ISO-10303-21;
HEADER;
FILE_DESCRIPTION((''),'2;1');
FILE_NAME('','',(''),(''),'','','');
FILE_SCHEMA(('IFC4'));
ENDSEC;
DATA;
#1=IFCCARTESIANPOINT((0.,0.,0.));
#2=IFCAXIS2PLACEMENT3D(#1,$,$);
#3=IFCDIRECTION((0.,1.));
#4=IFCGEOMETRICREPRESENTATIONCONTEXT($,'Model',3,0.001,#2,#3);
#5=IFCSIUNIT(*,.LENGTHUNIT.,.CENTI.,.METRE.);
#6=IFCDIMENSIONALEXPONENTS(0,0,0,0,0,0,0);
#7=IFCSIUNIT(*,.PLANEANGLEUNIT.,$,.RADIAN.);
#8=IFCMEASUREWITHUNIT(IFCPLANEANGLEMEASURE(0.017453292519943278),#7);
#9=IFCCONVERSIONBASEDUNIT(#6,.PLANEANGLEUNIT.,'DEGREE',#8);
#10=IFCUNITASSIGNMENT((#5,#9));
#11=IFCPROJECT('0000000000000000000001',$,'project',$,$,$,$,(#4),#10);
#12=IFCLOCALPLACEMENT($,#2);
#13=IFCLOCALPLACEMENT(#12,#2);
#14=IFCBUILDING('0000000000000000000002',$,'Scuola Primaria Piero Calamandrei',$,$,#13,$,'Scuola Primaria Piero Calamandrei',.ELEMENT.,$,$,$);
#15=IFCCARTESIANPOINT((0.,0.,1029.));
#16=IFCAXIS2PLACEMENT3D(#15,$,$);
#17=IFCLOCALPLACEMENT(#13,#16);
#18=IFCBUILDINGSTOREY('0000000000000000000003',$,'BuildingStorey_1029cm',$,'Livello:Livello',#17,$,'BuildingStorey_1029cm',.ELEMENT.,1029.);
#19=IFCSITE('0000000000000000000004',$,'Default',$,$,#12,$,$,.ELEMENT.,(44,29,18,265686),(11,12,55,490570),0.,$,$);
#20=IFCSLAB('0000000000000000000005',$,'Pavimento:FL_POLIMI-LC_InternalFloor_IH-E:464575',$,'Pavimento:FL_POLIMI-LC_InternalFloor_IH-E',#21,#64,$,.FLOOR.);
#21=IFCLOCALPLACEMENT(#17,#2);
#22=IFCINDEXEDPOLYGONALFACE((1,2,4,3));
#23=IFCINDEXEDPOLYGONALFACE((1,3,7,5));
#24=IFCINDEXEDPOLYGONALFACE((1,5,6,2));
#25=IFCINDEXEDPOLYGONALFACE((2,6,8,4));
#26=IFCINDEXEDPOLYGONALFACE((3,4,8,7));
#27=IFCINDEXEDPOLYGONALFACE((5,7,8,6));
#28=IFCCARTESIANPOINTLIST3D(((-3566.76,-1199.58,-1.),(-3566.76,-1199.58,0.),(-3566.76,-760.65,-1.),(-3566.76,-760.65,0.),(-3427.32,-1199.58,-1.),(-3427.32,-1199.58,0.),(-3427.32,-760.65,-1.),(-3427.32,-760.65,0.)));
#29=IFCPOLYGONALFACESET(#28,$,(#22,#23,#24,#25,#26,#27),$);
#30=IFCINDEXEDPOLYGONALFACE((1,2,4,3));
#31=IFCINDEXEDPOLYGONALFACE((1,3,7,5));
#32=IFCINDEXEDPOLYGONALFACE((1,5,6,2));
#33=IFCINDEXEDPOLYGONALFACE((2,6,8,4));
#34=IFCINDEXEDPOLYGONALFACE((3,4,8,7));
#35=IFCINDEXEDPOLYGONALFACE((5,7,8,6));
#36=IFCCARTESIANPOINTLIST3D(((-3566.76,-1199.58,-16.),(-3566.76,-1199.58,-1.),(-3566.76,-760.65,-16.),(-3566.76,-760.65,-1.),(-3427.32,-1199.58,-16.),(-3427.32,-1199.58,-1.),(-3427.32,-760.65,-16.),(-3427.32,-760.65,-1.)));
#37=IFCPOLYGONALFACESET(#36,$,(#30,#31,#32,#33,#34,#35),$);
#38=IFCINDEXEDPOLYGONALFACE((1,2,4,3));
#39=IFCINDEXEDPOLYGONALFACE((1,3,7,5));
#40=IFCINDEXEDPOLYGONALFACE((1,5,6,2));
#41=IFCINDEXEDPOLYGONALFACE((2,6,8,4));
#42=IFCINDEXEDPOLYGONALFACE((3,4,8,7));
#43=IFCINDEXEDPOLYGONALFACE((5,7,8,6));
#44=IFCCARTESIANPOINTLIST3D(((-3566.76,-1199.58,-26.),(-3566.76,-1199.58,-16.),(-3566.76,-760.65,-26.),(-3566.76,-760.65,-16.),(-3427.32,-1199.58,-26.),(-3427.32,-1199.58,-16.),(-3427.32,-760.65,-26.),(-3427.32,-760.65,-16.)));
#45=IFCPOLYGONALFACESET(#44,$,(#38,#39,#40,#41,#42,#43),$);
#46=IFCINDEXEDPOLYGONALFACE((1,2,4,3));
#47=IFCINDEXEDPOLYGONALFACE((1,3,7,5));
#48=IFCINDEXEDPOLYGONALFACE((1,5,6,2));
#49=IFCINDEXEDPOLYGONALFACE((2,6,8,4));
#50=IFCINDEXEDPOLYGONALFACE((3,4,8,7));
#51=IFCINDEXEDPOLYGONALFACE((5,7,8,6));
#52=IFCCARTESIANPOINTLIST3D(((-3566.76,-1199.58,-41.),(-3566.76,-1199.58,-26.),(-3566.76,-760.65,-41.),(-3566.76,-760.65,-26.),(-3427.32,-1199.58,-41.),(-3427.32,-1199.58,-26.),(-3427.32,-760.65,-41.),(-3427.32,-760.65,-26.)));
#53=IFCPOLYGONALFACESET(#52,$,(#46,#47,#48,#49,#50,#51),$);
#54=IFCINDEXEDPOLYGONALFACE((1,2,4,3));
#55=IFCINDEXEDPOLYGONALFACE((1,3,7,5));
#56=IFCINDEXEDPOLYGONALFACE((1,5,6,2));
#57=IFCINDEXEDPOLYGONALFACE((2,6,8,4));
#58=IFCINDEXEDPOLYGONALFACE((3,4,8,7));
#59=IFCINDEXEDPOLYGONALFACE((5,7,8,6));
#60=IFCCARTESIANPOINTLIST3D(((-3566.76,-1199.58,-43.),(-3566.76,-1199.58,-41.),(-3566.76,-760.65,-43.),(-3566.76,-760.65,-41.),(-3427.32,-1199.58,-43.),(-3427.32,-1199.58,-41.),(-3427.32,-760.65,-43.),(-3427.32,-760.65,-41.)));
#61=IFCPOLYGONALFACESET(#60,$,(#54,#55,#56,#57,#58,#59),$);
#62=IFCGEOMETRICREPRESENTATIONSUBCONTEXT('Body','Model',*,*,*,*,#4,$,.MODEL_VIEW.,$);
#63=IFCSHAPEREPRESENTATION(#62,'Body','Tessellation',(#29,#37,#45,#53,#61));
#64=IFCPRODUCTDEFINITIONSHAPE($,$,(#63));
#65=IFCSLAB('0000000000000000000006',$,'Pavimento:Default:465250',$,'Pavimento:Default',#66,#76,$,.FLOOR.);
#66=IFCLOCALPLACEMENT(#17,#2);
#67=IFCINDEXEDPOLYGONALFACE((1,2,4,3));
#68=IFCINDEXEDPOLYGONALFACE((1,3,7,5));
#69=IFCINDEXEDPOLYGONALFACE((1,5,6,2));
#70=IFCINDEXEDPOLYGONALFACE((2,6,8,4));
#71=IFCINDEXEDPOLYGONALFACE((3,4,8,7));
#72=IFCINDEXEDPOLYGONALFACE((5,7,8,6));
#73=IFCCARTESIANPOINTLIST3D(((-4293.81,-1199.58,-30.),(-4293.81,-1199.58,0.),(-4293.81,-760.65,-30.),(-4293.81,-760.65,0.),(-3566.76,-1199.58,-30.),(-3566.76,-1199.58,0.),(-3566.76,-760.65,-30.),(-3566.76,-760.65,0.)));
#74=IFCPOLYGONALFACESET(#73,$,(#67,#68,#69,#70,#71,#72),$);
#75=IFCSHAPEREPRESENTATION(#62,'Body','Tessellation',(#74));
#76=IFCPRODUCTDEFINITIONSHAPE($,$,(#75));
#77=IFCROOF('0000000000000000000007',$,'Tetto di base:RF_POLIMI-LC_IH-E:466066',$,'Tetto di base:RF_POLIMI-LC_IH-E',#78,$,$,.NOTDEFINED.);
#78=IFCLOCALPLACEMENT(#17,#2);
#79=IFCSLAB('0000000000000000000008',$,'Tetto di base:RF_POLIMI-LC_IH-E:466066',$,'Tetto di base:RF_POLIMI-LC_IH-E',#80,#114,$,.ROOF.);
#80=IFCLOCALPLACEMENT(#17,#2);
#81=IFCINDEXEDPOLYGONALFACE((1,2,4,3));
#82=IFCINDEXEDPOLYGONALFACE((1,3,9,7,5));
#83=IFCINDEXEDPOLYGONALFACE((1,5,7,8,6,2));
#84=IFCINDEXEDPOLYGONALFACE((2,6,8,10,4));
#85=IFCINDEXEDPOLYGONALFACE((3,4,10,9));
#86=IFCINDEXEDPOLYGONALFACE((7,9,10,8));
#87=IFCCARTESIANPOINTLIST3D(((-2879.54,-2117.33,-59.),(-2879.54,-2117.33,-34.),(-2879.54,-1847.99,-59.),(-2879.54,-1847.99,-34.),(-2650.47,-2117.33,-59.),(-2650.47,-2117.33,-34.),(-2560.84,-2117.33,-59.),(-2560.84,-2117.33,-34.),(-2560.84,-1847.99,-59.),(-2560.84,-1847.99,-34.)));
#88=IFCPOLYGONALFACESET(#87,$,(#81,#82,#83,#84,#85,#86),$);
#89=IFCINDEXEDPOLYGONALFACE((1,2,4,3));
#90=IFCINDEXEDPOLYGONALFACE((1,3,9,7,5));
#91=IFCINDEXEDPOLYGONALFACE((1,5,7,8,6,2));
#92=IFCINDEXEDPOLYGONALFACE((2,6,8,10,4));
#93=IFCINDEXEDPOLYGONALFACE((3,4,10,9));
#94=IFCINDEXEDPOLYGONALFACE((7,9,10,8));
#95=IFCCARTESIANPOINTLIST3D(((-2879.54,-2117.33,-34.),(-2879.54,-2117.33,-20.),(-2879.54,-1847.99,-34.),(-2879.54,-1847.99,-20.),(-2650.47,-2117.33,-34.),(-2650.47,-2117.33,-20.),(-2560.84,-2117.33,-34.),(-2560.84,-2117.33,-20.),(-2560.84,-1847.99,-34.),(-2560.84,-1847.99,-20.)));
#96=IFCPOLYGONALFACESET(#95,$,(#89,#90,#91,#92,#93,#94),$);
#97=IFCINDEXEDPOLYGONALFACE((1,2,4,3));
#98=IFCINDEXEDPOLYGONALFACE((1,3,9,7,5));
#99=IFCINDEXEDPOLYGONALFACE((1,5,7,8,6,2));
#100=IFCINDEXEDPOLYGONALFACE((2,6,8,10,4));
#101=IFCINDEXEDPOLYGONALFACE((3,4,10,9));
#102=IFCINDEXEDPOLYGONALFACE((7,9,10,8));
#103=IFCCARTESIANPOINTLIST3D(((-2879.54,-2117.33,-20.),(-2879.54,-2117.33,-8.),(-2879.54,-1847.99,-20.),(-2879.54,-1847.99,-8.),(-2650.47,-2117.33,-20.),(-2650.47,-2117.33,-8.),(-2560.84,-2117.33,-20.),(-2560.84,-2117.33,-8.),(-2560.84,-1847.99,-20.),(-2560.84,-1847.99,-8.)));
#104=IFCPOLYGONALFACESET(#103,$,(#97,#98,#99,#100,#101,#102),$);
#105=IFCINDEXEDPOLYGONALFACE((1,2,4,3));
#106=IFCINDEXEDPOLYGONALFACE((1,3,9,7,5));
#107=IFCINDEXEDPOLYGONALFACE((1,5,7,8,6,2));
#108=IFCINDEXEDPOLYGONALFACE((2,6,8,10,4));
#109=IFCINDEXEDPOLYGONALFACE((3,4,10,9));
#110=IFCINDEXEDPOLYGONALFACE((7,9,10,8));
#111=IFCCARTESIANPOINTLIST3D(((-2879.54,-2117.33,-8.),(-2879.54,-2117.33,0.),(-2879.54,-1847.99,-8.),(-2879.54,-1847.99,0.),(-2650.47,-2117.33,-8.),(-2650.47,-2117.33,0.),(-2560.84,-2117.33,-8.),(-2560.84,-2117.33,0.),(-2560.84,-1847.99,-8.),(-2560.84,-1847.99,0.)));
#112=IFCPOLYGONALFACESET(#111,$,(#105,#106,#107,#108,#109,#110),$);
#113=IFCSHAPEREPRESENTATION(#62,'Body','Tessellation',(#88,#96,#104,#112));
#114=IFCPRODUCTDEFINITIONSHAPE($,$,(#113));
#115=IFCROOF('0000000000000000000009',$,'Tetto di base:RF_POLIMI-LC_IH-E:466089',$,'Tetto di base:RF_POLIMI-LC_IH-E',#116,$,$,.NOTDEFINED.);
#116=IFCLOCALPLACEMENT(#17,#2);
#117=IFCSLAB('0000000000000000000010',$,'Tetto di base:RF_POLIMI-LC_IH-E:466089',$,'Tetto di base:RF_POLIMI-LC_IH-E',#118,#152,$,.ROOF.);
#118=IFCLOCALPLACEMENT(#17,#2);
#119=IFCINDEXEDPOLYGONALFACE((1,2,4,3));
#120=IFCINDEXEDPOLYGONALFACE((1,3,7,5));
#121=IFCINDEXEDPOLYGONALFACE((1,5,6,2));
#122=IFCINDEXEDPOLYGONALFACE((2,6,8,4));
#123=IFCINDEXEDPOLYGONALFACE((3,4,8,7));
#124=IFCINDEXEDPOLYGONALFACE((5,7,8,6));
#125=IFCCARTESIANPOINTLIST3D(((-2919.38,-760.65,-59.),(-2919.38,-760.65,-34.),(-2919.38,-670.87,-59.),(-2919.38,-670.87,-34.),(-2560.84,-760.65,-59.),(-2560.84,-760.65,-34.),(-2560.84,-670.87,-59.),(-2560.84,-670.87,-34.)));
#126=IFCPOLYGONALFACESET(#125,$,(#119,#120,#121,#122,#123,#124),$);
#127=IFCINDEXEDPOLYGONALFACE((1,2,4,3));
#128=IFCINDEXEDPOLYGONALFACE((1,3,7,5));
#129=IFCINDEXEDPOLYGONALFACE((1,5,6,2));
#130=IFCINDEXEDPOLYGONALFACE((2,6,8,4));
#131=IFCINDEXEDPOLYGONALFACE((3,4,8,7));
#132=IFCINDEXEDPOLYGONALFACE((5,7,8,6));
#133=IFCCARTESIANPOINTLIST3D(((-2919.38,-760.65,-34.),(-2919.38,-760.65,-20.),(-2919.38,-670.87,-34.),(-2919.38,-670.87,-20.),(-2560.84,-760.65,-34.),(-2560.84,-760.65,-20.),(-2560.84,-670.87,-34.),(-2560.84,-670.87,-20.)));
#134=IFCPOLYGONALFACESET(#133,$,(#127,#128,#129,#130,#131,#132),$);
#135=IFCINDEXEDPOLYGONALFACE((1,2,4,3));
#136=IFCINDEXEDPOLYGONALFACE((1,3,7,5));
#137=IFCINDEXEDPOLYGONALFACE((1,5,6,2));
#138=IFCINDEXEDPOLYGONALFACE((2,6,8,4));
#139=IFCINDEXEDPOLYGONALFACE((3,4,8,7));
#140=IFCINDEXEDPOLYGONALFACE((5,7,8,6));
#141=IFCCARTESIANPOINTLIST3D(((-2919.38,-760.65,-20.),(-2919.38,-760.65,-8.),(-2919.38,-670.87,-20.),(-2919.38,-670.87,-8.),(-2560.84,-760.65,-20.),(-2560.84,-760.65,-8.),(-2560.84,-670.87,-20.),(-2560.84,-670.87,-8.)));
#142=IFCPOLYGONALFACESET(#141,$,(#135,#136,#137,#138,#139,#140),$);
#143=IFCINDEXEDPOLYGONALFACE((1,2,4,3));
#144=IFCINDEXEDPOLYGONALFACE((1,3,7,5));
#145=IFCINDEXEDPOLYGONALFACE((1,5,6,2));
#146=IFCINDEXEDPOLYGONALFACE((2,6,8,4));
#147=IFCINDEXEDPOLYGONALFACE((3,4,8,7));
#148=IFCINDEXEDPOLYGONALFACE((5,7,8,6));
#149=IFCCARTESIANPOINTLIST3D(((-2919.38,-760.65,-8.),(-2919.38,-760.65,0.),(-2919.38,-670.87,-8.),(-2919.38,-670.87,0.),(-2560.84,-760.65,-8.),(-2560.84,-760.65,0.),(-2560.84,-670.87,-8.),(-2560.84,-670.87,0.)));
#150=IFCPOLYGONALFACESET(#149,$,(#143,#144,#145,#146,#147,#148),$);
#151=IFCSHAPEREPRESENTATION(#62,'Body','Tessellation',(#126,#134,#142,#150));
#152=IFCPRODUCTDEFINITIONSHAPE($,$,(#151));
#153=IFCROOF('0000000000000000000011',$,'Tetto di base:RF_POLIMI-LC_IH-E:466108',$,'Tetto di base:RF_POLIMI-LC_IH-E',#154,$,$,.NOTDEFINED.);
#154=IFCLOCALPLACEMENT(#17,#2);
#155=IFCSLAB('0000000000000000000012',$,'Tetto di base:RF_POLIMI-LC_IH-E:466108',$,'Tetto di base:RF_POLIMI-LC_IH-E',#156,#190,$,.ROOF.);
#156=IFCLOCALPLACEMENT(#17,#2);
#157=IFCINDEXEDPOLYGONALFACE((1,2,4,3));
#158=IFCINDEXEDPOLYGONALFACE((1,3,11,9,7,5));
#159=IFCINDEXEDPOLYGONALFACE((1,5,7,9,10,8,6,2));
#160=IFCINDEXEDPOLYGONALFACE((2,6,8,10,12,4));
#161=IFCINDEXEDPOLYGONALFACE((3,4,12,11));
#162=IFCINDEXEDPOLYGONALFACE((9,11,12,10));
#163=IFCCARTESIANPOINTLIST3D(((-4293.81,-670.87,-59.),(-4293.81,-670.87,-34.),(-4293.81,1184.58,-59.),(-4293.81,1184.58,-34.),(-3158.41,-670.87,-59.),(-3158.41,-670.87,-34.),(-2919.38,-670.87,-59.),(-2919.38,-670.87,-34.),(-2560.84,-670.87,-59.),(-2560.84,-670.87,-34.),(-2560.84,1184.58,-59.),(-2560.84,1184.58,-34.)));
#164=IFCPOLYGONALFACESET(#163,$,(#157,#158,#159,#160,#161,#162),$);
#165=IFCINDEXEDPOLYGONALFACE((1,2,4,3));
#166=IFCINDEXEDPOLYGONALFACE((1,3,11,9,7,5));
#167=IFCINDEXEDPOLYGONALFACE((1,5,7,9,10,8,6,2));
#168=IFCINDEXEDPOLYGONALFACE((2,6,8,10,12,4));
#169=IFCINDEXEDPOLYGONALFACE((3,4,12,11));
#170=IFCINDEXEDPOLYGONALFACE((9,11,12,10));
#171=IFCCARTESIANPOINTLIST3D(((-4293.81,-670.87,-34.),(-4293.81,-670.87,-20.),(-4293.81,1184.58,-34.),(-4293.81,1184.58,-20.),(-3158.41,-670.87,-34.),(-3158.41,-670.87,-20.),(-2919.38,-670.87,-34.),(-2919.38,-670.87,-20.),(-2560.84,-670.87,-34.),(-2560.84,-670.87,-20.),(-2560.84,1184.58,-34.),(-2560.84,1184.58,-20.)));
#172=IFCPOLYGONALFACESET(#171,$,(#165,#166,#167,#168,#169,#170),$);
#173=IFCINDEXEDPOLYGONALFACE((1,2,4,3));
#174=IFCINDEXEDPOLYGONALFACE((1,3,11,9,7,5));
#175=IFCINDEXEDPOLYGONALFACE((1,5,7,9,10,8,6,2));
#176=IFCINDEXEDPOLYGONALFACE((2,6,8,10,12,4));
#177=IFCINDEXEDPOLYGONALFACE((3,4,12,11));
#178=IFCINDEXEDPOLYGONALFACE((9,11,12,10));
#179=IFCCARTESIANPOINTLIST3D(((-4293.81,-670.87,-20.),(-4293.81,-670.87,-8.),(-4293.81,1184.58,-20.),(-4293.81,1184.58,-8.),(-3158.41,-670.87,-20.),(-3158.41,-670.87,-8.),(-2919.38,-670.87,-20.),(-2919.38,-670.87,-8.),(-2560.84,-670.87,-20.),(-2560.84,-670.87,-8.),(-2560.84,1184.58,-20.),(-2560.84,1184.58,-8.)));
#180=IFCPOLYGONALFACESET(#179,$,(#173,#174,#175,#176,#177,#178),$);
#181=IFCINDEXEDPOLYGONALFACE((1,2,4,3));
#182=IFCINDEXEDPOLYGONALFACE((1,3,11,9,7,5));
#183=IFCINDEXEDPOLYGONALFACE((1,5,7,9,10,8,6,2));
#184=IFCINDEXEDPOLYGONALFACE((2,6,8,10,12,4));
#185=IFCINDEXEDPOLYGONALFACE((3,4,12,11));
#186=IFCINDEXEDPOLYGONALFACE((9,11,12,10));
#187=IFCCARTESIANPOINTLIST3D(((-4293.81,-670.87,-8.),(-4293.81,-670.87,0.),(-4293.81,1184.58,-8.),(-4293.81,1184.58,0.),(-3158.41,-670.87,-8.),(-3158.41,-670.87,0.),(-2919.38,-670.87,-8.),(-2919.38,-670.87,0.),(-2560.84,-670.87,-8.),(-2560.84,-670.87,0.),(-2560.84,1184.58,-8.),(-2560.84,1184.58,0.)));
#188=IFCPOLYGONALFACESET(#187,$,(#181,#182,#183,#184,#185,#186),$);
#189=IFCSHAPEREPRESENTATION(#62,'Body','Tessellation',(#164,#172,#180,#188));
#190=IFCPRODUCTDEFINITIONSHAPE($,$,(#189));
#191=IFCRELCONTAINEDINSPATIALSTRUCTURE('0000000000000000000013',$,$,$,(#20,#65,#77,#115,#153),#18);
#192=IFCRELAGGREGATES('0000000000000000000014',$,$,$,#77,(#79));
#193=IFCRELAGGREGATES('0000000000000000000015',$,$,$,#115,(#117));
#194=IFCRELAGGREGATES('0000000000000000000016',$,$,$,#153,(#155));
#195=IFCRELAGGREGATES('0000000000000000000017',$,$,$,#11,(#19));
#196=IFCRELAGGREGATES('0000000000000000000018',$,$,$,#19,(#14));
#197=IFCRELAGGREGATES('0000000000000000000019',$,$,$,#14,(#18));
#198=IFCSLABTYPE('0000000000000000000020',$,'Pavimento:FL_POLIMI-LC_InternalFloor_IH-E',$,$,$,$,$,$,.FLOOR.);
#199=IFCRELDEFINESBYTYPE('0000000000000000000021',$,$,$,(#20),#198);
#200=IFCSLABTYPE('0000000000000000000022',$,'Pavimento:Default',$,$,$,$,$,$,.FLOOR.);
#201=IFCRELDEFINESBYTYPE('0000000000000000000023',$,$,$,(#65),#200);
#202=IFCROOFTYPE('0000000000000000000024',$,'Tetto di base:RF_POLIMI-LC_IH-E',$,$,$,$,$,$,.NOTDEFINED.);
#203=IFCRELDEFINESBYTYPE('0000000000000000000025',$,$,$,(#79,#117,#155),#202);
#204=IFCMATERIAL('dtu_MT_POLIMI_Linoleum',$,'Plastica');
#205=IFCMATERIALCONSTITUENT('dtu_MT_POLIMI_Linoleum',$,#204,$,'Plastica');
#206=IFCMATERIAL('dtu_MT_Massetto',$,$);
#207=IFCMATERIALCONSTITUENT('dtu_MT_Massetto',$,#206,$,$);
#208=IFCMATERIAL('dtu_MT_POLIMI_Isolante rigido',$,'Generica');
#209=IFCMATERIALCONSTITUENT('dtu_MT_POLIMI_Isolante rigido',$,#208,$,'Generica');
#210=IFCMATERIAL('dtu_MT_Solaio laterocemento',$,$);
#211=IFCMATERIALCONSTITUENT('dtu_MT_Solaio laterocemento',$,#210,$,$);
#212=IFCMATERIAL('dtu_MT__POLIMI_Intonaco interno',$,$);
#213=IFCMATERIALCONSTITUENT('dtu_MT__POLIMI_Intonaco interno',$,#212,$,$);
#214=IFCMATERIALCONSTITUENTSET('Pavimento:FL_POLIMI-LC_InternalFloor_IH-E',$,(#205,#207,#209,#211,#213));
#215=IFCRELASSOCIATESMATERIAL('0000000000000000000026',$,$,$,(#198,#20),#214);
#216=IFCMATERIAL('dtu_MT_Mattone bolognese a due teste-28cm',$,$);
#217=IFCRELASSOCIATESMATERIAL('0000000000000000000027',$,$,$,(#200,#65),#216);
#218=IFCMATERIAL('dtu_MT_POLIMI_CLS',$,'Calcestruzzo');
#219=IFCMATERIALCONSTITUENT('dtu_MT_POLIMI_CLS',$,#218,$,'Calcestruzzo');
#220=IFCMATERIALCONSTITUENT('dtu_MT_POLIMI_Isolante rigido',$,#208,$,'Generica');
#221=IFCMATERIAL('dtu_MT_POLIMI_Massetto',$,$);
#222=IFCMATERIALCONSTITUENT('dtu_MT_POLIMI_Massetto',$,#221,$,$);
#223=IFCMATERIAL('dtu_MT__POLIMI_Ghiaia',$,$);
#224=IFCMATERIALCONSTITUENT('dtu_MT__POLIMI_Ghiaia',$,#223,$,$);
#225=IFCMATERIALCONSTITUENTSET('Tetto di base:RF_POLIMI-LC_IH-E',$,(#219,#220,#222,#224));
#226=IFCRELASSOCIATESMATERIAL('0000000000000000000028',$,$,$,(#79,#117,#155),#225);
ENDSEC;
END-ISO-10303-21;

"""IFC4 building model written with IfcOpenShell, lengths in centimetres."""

from ifc_helpers import new_model, entity, si_unit, converted_unit, direction, frame, origin, place, context, subcontext, project, spatial, indexed_curve, outline, extrude, material, constituent, constituent_set, type_object, element, aggregate, save


model = new_model("IFC4")

# Units and contexts
model_context = context("Model", 3, precision=0.001, world=origin(), true_north=direction((0.0, 1.0)))
body_context = subcontext(model_context, "Body", "Model", "MODEL_VIEW")
ifc_project = project(units=[si_unit("LENGTHUNIT", "METRE", prefix="CENTI"), converted_unit("PLANEANGLEUNIT", "DEGREE", entity("IfcPlaneAngleMeasure", 0.017453292519943278), si_unit("PLANEANGLEUNIT", "RADIAN"), dimensions=[0, 0, 0, 0, 0, 0, 0])], contexts=[model_context])

# Site, building, storey
site_placement = place(None, origin())
site = spatial("IfcSite", under=ifc_project, at=site_placement, Name="Default", CompositionType="ELEMENT", RefLatitude=(44, 29, 18, 265686), RefLongitude=(11, 12, 55, 490570), RefElevation=0.0)
building_placement = place(site_placement, origin())
building = spatial("IfcBuilding", under=site, at=building_placement, Name="Scuola Primaria Piero Calamandrei", LongName="Scuola Primaria Piero Calamandrei", CompositionType="ELEMENT")
storey_placement = place(building_placement, frame((0.0, 0.0, 1029.0)))
storey = spatial("IfcBuildingStorey", under=building, at=storey_placement, Name="BuildingStorey_1029cm", ObjectType="Livello:Livello", LongName="BuildingStorey_1029cm", CompositionType="ELEMENT", Elevation=1029.0)

# Slabs
ifc_material_1 = material(Name="dtu_MT_POLIMI_Linoleum", Category="Plastica")
ifc_constituent_1 = constituent(ifc_material_1, Name="dtu_MT_POLIMI_Linoleum", Category="Plastica")
ifc_material_2 = material(Name="dtu_MT_Massetto")
ifc_constituent_2 = constituent(ifc_material_2, Name="dtu_MT_Massetto")
ifc_material_3 = material(Name="dtu_MT_POLIMI_Isolante rigido", Category="Generica")
ifc_constituent_3 = constituent(ifc_material_3, Name="dtu_MT_POLIMI_Isolante rigido", Category="Generica")
ifc_material_4 = material(Name="dtu_MT_Solaio laterocemento")
ifc_constituent_4 = constituent(ifc_material_4, Name="dtu_MT_Solaio laterocemento")
ifc_material_5 = material(Name="dtu_MT__POLIMI_Intonaco interno")
ifc_constituent_5 = constituent(ifc_material_5, Name="dtu_MT__POLIMI_Intonaco interno")
ifc_constituent_set_1 = constituent_set(constituents=[ifc_constituent_1, ifc_constituent_2, ifc_constituent_3, ifc_constituent_4, ifc_constituent_5], Name="Pavimento:FL_POLIMI-LC_InternalFloor_IH-E")
slab_type_1 = type_object("IfcSlabType", Name="Pavimento:FL_POLIMI-LC_InternalFloor_IH-E", PredefinedType="FLOOR", material=ifc_constituent_set_1)
slab_1_placement = place(storey_placement, origin())
element("IfcSlab", 1, at=slab_1_placement, inside=storey, type_object=slab_type_1, material=ifc_constituent_set_1, Name="Pavimento:FL_POLIMI-LC_InternalFloor_IH-E:464575", ObjectType="Pavimento:FL_POLIMI-LC_InternalFloor_IH-E", PredefinedType="FLOOR", context=body_context, shape_type="SweptSolid", body=[
    extrude(outline(indexed_curve([(-69.72, -219.46), (69.72, -219.46), (69.72, 219.46), (-69.72, 219.46), (-69.72, -219.46)], self_intersect=False)), frame((-3497.04, -980.11, -1.0)), (0.0, 0.0, 1.0), 1.0),
    extrude(outline(indexed_curve([(-69.72, -219.46), (69.72, -219.46), (69.72, 219.46), (-69.72, 219.46), (-69.72, -219.46)], self_intersect=False)), frame((-3497.04, -980.11, -16.0)), (0.0, 0.0, 1.0), 15.0),
    extrude(outline(indexed_curve([(-69.72, -219.46), (69.72, -219.46), (69.72, 219.46), (-69.72, 219.46), (-69.72, -219.46)], self_intersect=False)), frame((-3497.04, -980.11, -26.0)), (0.0, 0.0, 1.0), 10.0),
    extrude(outline(indexed_curve([(-69.72, -219.46), (69.72, -219.46), (69.72, 219.46), (-69.72, 219.46), (-69.72, -219.46)], self_intersect=False)), frame((-3497.04, -980.11, -41.0)), (0.0, 0.0, 1.0), 15.0),
    extrude(outline(indexed_curve([(-69.72, -219.46), (69.72, -219.46), (69.72, 219.46), (-69.72, 219.46), (-69.72, -219.46)], self_intersect=False)), frame((-3497.04, -980.11, -43.0)), (0.0, 0.0, 1.0), 2.0),
])
ifc_material_6 = material(Name="dtu_MT_Mattone bolognese a due teste-28cm")
slab_type_2 = type_object("IfcSlabType", Name="Pavimento:Default", PredefinedType="FLOOR", material=ifc_material_6)
slab_2_placement = place(storey_placement, origin())
element("IfcSlab", 2, at=slab_2_placement, inside=storey, type_object=slab_type_2, material=ifc_material_6, Name="Pavimento:Default:465250", ObjectType="Pavimento:Default", PredefinedType="FLOOR", context=body_context, shape_type="SweptSolid", body=[
    extrude(outline(indexed_curve([(-219.46, -363.53), (219.46, -363.53), (219.46, 363.53), (-219.46, 363.53), (-219.46, -363.53)], self_intersect=False)), frame((-3930.28, -980.11, 0.0), z_axis=(0.0, 0.0, -1.0), x_axis=(0.0, 1.0, 0.0)), (0.0, 0.0, 1.0), 30.0),
])

# Roofs, slabs
ifc_material_7 = material(Name="dtu_MT_POLIMI_CLS", Category="Calcestruzzo")
ifc_constituent_6 = constituent(ifc_material_7, Name="dtu_MT_POLIMI_CLS", Category="Calcestruzzo")
ifc_constituent_7 = constituent(ifc_material_3, Name="dtu_MT_POLIMI_Isolante rigido", Category="Generica")
ifc_material_8 = material(Name="dtu_MT_POLIMI_Massetto")
ifc_constituent_8 = constituent(ifc_material_8, Name="dtu_MT_POLIMI_Massetto")
ifc_material_9 = material(Name="dtu_MT__POLIMI_Ghiaia")
ifc_constituent_9 = constituent(ifc_material_9, Name="dtu_MT__POLIMI_Ghiaia")
ifc_constituent_set_2 = constituent_set(constituents=[ifc_constituent_6, ifc_constituent_7, ifc_constituent_8, ifc_constituent_9], Name="Tetto di base:RF_POLIMI-LC_IH-E")
roof_type = type_object("IfcRoofType", Name="Tetto di base:RF_POLIMI-LC_IH-E", PredefinedType="NOTDEFINED")
roof_1_placement = place(storey_placement, frame((-2879.54, -2117.33, -59.0)))
roof_1 = element("IfcRoof", 3, at=roof_1_placement, inside=storey, Name="Tetto di base:RF_POLIMI-LC_IH-E:466066", ObjectType="Tetto di base:RF_POLIMI-LC_IH-E", PredefinedType="NOTDEFINED")
slab_3_placement = place(roof_1_placement, origin())
slab_3 = element("IfcSlab", 4, at=slab_3_placement, type_object=roof_type, material=ifc_constituent_set_2, Name="Tetto di base:RF_POLIMI-LC_IH-E:466066", ObjectType="Tetto di base:RF_POLIMI-LC_IH-E", PredefinedType="ROOF", context=body_context, shape_type="SweptSolid", body=[
    extrude(outline(indexed_curve([(-159.35, -134.67), (69.72, -134.67), (159.35, -134.67), (159.35, 134.67), (-159.35, 134.67), (-159.35, -134.67)], self_intersect=False)), frame((159.35, 134.67, 0.0)), (0.0, 0.0, 1.0), 25.0),
    extrude(outline(indexed_curve([(-159.35, -134.67), (69.72, -134.67), (159.35, -134.67), (159.35, 134.67), (-159.35, 134.67), (-159.35, -134.67)], self_intersect=False)), frame((159.35, 134.67, 25.0)), (0.0, 0.0, 1.0), 14.0),
    extrude(outline(indexed_curve([(-159.35, -134.67), (69.72, -134.67), (159.35, -134.67), (159.35, 134.67), (-159.35, 134.67), (-159.35, -134.67)], self_intersect=False)), frame((159.35, 134.67, 39.0)), (0.0, 0.0, 1.0), 12.0),
    extrude(outline(indexed_curve([(-159.35, -134.67), (69.72, -134.67), (159.35, -134.67), (159.35, 134.67), (-159.35, 134.67), (-159.35, -134.67)], self_intersect=False)), frame((159.35, 134.67, 51.0)), (0.0, 0.0, 1.0), 8.0),
])
aggregate(roof_1, [slab_3])
roof_2_placement = place(storey_placement, frame((-2919.38, -760.65, -59.0)))
roof_2 = element("IfcRoof", 5, at=roof_2_placement, inside=storey, Name="Tetto di base:RF_POLIMI-LC_IH-E:466089", ObjectType="Tetto di base:RF_POLIMI-LC_IH-E", PredefinedType="NOTDEFINED")
slab_4_placement = place(roof_2_placement, origin())
slab_4 = element("IfcSlab", 6, at=slab_4_placement, type_object=roof_type, material=ifc_constituent_set_2, Name="Tetto di base:RF_POLIMI-LC_IH-E:466089", ObjectType="Tetto di base:RF_POLIMI-LC_IH-E", PredefinedType="ROOF", context=body_context, shape_type="SweptSolid", body=[
    extrude(outline(indexed_curve([(-179.27, 44.89), (-179.27, -44.89), (179.27, -44.89), (179.27, 44.89), (-179.27, 44.89)], self_intersect=False)), frame((179.27, 44.89, 0.0)), (0.0, 0.0, 1.0), 25.0),
    extrude(outline(indexed_curve([(-179.27, 44.89), (-179.27, -44.89), (179.27, -44.89), (179.27, 44.89), (-179.27, 44.89)], self_intersect=False)), frame((179.27, 44.89, 25.0)), (0.0, 0.0, 1.0), 14.0),
    extrude(outline(indexed_curve([(-179.27, 44.89), (-179.27, -44.89), (179.27, -44.89), (179.27, 44.89), (-179.27, 44.89)], self_intersect=False)), frame((179.27, 44.89, 39.0)), (0.0, 0.0, 1.0), 12.0),
    extrude(outline(indexed_curve([(-179.27, 44.89), (-179.27, -44.89), (179.27, -44.89), (179.27, 44.89), (-179.27, 44.89)], self_intersect=False)), frame((179.27, 44.89, 51.0)), (0.0, 0.0, 1.0), 8.0),
])
aggregate(roof_2, [slab_4])
roof_3_placement = place(storey_placement, frame((-4293.81, -670.87, -59.0)))
roof_3 = element("IfcRoof", 7, at=roof_3_placement, inside=storey, Name="Tetto di base:RF_POLIMI-LC_IH-E:466108", ObjectType="Tetto di base:RF_POLIMI-LC_IH-E", PredefinedType="NOTDEFINED")
slab_5_placement = place(roof_3_placement, origin())
slab_5 = element("IfcSlab", 8, at=slab_5_placement, type_object=roof_type, material=ifc_constituent_set_2, Name="Tetto di base:RF_POLIMI-LC_IH-E:466108", ObjectType="Tetto di base:RF_POLIMI-LC_IH-E", PredefinedType="ROOF", context=body_context, shape_type="SweptSolid", body=[
    extrude(outline(indexed_curve([(866.49, -927.73), (866.49, 927.73), (-866.49, 927.73), (-866.49, -927.73), (268.91, -927.73), (507.94, -927.73), (866.49, -927.73)], self_intersect=False)), frame((866.49, 927.73, 0.0)), (0.0, 0.0, 1.0), 25.0),
    extrude(outline(indexed_curve([(866.49, -927.73), (866.49, 927.73), (-866.49, 927.73), (-866.49, -927.73), (268.91, -927.73), (507.94, -927.73), (866.49, -927.73)], self_intersect=False)), frame((866.49, 927.73, 25.0)), (0.0, 0.0, 1.0), 14.0),
    extrude(outline(indexed_curve([(866.49, -927.73), (866.49, 927.73), (-866.49, 927.73), (-866.49, -927.73), (268.91, -927.73), (507.94, -927.73), (866.49, -927.73)], self_intersect=False)), frame((866.49, 927.73, 39.0)), (0.0, 0.0, 1.0), 12.0),
    extrude(outline(indexed_curve([(866.49, -927.73), (866.49, 927.73), (-866.49, 927.73), (-866.49, -927.73), (268.91, -927.73), (507.94, -927.73), (866.49, -927.73)], self_intersect=False)), frame((866.49, 927.73, 51.0)), (0.0, 0.0, 1.0), 8.0),
])
aggregate(roof_3, [slab_5])

save(model, "model.ifc")
